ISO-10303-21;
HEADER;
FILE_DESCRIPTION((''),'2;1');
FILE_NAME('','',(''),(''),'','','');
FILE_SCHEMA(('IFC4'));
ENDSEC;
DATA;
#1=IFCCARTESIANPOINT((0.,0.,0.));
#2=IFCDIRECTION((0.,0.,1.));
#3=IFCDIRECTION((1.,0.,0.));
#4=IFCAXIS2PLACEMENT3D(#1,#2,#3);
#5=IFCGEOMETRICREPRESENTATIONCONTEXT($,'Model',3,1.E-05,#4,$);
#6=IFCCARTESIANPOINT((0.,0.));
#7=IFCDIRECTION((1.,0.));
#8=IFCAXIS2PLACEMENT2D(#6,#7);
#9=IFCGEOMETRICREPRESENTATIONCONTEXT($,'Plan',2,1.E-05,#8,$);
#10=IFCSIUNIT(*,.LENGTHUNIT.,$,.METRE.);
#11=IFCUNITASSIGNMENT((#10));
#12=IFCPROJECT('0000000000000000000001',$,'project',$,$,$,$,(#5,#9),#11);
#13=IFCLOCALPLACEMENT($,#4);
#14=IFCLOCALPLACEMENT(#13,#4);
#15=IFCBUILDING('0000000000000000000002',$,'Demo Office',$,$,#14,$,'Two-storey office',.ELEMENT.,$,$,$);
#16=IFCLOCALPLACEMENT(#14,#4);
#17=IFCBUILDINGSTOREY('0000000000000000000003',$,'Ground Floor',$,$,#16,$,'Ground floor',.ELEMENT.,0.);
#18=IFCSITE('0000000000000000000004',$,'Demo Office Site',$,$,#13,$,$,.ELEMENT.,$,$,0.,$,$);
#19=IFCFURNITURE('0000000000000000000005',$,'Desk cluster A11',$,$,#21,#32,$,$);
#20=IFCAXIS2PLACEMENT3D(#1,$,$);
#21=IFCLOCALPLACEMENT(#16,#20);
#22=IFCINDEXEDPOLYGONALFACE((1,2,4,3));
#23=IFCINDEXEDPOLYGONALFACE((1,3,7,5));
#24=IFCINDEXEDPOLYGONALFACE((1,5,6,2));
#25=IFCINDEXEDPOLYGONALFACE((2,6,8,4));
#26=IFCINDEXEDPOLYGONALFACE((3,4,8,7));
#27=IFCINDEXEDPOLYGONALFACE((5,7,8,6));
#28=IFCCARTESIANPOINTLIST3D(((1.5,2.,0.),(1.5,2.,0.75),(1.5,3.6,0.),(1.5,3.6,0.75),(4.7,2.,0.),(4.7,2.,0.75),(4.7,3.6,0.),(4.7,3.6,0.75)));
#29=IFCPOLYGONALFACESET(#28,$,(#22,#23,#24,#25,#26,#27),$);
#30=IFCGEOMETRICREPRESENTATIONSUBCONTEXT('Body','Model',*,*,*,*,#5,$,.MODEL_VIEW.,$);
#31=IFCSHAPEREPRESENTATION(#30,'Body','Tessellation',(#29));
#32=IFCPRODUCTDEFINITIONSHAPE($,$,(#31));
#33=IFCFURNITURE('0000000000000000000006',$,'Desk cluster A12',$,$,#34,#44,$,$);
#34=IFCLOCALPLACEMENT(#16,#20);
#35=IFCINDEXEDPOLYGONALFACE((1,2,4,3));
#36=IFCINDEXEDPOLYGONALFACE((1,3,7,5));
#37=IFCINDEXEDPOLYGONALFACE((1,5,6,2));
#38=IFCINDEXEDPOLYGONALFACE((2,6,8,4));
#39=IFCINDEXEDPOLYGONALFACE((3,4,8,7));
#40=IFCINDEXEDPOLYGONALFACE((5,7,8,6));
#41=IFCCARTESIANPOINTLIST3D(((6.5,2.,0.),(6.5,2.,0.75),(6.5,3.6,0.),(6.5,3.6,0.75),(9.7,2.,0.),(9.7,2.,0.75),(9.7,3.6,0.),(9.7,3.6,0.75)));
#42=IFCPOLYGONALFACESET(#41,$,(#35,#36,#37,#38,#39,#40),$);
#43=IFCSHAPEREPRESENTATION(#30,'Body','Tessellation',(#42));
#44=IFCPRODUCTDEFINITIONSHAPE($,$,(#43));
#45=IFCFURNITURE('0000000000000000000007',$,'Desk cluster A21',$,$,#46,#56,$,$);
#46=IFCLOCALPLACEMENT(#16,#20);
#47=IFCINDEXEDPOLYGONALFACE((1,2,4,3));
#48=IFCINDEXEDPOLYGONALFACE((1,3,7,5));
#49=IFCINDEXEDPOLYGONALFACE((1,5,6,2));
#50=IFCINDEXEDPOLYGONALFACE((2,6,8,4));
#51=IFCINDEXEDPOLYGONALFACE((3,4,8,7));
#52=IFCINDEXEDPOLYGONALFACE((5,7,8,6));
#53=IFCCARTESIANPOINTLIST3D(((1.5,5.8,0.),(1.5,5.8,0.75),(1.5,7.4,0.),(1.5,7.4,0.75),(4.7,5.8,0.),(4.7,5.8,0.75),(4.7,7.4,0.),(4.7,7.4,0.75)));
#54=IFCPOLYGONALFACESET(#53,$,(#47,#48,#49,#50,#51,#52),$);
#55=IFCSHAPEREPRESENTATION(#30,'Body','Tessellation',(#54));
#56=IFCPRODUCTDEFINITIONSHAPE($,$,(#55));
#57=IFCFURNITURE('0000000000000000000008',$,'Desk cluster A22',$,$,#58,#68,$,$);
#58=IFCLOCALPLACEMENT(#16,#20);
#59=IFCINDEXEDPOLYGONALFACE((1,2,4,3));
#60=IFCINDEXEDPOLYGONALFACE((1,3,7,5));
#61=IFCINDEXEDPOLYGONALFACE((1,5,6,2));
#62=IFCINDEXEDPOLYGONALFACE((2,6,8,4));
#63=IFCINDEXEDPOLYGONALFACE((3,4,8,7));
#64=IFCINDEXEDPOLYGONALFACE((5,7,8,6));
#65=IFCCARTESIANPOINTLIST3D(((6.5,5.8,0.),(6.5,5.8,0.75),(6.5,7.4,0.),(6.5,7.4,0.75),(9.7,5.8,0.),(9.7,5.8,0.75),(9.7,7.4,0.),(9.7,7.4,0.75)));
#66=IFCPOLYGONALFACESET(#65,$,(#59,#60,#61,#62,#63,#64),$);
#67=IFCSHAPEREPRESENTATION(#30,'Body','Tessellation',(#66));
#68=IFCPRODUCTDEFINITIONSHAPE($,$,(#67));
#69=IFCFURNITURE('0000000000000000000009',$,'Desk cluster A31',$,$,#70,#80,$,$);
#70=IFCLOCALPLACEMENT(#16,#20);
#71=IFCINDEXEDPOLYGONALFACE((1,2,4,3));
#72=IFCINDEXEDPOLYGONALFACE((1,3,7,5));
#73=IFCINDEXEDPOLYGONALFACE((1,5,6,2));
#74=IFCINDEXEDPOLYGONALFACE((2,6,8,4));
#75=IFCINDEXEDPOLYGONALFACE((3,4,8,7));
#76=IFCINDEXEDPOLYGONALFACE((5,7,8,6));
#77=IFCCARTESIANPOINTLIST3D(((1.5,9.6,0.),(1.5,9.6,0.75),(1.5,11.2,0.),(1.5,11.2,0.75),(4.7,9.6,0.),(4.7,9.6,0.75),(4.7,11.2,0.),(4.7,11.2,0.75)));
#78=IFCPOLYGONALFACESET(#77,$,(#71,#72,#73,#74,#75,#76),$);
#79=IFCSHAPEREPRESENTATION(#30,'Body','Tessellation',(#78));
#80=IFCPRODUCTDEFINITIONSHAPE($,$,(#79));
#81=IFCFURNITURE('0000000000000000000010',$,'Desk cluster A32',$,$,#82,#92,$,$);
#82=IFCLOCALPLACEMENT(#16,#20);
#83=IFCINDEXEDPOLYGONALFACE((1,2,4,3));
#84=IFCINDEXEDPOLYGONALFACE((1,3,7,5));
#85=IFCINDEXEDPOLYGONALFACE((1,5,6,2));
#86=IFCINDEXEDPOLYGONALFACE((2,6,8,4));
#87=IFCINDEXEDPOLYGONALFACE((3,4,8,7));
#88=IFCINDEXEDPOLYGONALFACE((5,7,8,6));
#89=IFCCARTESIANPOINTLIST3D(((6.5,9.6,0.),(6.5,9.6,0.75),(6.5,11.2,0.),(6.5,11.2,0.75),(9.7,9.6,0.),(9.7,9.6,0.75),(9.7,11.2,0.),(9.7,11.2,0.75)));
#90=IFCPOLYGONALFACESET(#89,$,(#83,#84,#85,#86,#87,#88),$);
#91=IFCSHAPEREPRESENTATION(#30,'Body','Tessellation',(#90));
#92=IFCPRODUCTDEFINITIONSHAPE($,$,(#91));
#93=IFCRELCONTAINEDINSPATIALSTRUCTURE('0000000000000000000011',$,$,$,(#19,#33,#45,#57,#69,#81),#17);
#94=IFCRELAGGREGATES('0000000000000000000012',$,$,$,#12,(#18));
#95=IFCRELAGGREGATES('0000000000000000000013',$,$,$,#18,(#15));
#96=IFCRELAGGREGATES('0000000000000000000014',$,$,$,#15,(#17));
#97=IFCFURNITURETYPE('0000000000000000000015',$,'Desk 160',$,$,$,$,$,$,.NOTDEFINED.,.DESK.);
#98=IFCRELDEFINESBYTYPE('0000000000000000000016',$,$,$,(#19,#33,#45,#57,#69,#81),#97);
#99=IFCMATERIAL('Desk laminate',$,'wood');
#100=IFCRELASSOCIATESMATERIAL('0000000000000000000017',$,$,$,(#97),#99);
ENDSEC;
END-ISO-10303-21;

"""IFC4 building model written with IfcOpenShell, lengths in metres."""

from ifc_helpers import new_model, si_unit, frame, origin_with_axes, origin_2d_with_axis, place, context, subcontext, project, spatial, line, indexed_curve, outline, extrude, material, type_object, element, save


model = new_model("IFC4")

# Units and contexts
model_context = context("Model", 3, precision=1e-05, world=origin_with_axes())
plan_context = context("Plan", 2, precision=1e-05, world=origin_2d_with_axis())
body_context = subcontext(model_context, "Body", "Model", "MODEL_VIEW")
ifc_project = project(units=[si_unit("LENGTHUNIT", "METRE")], contexts=[model_context, plan_context])

# Site, building, storey
site_placement = place(None, origin_with_axes())
site = spatial("IfcSite", under=ifc_project, at=site_placement, Name="Demo Office Site", CompositionType="ELEMENT", RefElevation=0.0)
building_placement = place(site_placement, origin_with_axes())
building = spatial("IfcBuilding", under=site, at=building_placement, Name="Demo Office", LongName="Two-storey office", CompositionType="ELEMENT")
storey_placement = place(building_placement, origin_with_axes())
storey = spatial("IfcBuildingStorey", under=building, at=storey_placement, Name="Ground Floor", LongName="Ground floor", CompositionType="ELEMENT", Elevation=0.0)

# Furniture
ifc_material_1 = material(Name="Desk laminate", Category="wood")
furniture_type = type_object("IfcFurnitureType", Name="Desk 160", AssemblyPlace="NOTDEFINED", PredefinedType="DESK", material=ifc_material_1)
for number, where, z_axis, x_axis, name in (
    (1, (1.5, 2.0, 0.0), (0.0, 0.0, 1.0), (1.0, 0.0, 0.0), "Desk cluster A11"),
    (2, (6.5, 2.0, 0.0), (0.0, 0.0, 1.0), (1.0, 0.0, 0.0), "Desk cluster A12"),
    (3, (1.5, 5.8, 0.0), (0.0, 0.0, 1.0), (1.0, 0.0, 0.0), "Desk cluster A21"),
    (4, (6.5, 5.8, 0.0), (0.0, 0.0, 1.0), (1.0, 0.0, 0.0), "Desk cluster A22"),
    (5, (1.5, 9.6, 0.0), (0.0, 0.0, 1.0), (1.0, 0.0, 0.0), "Desk cluster A31"),
    (6, (6.5, 9.6, 0.0), (0.0, 0.0, 1.0), (1.0, 0.0, 0.0), "Desk cluster A32"),
):
    element("IfcFurniture", number, at=place(storey_placement, frame(where, z_axis=z_axis, x_axis=x_axis)), inside=storey, type_object=furniture_type, Name=name, context=body_context, shape_type="SweptSolid", body=[
        extrude(outline(indexed_curve([(0.0, 0.0), (3.2, 0.0), (3.2, 1.6), (0.0, 1.6)], segments=[line(1, 2, 3, 4, 1)])), origin_with_axes(), (0.0, 0.0, 1.0), 0.75),
    ])

save(model, "model.ifc")
